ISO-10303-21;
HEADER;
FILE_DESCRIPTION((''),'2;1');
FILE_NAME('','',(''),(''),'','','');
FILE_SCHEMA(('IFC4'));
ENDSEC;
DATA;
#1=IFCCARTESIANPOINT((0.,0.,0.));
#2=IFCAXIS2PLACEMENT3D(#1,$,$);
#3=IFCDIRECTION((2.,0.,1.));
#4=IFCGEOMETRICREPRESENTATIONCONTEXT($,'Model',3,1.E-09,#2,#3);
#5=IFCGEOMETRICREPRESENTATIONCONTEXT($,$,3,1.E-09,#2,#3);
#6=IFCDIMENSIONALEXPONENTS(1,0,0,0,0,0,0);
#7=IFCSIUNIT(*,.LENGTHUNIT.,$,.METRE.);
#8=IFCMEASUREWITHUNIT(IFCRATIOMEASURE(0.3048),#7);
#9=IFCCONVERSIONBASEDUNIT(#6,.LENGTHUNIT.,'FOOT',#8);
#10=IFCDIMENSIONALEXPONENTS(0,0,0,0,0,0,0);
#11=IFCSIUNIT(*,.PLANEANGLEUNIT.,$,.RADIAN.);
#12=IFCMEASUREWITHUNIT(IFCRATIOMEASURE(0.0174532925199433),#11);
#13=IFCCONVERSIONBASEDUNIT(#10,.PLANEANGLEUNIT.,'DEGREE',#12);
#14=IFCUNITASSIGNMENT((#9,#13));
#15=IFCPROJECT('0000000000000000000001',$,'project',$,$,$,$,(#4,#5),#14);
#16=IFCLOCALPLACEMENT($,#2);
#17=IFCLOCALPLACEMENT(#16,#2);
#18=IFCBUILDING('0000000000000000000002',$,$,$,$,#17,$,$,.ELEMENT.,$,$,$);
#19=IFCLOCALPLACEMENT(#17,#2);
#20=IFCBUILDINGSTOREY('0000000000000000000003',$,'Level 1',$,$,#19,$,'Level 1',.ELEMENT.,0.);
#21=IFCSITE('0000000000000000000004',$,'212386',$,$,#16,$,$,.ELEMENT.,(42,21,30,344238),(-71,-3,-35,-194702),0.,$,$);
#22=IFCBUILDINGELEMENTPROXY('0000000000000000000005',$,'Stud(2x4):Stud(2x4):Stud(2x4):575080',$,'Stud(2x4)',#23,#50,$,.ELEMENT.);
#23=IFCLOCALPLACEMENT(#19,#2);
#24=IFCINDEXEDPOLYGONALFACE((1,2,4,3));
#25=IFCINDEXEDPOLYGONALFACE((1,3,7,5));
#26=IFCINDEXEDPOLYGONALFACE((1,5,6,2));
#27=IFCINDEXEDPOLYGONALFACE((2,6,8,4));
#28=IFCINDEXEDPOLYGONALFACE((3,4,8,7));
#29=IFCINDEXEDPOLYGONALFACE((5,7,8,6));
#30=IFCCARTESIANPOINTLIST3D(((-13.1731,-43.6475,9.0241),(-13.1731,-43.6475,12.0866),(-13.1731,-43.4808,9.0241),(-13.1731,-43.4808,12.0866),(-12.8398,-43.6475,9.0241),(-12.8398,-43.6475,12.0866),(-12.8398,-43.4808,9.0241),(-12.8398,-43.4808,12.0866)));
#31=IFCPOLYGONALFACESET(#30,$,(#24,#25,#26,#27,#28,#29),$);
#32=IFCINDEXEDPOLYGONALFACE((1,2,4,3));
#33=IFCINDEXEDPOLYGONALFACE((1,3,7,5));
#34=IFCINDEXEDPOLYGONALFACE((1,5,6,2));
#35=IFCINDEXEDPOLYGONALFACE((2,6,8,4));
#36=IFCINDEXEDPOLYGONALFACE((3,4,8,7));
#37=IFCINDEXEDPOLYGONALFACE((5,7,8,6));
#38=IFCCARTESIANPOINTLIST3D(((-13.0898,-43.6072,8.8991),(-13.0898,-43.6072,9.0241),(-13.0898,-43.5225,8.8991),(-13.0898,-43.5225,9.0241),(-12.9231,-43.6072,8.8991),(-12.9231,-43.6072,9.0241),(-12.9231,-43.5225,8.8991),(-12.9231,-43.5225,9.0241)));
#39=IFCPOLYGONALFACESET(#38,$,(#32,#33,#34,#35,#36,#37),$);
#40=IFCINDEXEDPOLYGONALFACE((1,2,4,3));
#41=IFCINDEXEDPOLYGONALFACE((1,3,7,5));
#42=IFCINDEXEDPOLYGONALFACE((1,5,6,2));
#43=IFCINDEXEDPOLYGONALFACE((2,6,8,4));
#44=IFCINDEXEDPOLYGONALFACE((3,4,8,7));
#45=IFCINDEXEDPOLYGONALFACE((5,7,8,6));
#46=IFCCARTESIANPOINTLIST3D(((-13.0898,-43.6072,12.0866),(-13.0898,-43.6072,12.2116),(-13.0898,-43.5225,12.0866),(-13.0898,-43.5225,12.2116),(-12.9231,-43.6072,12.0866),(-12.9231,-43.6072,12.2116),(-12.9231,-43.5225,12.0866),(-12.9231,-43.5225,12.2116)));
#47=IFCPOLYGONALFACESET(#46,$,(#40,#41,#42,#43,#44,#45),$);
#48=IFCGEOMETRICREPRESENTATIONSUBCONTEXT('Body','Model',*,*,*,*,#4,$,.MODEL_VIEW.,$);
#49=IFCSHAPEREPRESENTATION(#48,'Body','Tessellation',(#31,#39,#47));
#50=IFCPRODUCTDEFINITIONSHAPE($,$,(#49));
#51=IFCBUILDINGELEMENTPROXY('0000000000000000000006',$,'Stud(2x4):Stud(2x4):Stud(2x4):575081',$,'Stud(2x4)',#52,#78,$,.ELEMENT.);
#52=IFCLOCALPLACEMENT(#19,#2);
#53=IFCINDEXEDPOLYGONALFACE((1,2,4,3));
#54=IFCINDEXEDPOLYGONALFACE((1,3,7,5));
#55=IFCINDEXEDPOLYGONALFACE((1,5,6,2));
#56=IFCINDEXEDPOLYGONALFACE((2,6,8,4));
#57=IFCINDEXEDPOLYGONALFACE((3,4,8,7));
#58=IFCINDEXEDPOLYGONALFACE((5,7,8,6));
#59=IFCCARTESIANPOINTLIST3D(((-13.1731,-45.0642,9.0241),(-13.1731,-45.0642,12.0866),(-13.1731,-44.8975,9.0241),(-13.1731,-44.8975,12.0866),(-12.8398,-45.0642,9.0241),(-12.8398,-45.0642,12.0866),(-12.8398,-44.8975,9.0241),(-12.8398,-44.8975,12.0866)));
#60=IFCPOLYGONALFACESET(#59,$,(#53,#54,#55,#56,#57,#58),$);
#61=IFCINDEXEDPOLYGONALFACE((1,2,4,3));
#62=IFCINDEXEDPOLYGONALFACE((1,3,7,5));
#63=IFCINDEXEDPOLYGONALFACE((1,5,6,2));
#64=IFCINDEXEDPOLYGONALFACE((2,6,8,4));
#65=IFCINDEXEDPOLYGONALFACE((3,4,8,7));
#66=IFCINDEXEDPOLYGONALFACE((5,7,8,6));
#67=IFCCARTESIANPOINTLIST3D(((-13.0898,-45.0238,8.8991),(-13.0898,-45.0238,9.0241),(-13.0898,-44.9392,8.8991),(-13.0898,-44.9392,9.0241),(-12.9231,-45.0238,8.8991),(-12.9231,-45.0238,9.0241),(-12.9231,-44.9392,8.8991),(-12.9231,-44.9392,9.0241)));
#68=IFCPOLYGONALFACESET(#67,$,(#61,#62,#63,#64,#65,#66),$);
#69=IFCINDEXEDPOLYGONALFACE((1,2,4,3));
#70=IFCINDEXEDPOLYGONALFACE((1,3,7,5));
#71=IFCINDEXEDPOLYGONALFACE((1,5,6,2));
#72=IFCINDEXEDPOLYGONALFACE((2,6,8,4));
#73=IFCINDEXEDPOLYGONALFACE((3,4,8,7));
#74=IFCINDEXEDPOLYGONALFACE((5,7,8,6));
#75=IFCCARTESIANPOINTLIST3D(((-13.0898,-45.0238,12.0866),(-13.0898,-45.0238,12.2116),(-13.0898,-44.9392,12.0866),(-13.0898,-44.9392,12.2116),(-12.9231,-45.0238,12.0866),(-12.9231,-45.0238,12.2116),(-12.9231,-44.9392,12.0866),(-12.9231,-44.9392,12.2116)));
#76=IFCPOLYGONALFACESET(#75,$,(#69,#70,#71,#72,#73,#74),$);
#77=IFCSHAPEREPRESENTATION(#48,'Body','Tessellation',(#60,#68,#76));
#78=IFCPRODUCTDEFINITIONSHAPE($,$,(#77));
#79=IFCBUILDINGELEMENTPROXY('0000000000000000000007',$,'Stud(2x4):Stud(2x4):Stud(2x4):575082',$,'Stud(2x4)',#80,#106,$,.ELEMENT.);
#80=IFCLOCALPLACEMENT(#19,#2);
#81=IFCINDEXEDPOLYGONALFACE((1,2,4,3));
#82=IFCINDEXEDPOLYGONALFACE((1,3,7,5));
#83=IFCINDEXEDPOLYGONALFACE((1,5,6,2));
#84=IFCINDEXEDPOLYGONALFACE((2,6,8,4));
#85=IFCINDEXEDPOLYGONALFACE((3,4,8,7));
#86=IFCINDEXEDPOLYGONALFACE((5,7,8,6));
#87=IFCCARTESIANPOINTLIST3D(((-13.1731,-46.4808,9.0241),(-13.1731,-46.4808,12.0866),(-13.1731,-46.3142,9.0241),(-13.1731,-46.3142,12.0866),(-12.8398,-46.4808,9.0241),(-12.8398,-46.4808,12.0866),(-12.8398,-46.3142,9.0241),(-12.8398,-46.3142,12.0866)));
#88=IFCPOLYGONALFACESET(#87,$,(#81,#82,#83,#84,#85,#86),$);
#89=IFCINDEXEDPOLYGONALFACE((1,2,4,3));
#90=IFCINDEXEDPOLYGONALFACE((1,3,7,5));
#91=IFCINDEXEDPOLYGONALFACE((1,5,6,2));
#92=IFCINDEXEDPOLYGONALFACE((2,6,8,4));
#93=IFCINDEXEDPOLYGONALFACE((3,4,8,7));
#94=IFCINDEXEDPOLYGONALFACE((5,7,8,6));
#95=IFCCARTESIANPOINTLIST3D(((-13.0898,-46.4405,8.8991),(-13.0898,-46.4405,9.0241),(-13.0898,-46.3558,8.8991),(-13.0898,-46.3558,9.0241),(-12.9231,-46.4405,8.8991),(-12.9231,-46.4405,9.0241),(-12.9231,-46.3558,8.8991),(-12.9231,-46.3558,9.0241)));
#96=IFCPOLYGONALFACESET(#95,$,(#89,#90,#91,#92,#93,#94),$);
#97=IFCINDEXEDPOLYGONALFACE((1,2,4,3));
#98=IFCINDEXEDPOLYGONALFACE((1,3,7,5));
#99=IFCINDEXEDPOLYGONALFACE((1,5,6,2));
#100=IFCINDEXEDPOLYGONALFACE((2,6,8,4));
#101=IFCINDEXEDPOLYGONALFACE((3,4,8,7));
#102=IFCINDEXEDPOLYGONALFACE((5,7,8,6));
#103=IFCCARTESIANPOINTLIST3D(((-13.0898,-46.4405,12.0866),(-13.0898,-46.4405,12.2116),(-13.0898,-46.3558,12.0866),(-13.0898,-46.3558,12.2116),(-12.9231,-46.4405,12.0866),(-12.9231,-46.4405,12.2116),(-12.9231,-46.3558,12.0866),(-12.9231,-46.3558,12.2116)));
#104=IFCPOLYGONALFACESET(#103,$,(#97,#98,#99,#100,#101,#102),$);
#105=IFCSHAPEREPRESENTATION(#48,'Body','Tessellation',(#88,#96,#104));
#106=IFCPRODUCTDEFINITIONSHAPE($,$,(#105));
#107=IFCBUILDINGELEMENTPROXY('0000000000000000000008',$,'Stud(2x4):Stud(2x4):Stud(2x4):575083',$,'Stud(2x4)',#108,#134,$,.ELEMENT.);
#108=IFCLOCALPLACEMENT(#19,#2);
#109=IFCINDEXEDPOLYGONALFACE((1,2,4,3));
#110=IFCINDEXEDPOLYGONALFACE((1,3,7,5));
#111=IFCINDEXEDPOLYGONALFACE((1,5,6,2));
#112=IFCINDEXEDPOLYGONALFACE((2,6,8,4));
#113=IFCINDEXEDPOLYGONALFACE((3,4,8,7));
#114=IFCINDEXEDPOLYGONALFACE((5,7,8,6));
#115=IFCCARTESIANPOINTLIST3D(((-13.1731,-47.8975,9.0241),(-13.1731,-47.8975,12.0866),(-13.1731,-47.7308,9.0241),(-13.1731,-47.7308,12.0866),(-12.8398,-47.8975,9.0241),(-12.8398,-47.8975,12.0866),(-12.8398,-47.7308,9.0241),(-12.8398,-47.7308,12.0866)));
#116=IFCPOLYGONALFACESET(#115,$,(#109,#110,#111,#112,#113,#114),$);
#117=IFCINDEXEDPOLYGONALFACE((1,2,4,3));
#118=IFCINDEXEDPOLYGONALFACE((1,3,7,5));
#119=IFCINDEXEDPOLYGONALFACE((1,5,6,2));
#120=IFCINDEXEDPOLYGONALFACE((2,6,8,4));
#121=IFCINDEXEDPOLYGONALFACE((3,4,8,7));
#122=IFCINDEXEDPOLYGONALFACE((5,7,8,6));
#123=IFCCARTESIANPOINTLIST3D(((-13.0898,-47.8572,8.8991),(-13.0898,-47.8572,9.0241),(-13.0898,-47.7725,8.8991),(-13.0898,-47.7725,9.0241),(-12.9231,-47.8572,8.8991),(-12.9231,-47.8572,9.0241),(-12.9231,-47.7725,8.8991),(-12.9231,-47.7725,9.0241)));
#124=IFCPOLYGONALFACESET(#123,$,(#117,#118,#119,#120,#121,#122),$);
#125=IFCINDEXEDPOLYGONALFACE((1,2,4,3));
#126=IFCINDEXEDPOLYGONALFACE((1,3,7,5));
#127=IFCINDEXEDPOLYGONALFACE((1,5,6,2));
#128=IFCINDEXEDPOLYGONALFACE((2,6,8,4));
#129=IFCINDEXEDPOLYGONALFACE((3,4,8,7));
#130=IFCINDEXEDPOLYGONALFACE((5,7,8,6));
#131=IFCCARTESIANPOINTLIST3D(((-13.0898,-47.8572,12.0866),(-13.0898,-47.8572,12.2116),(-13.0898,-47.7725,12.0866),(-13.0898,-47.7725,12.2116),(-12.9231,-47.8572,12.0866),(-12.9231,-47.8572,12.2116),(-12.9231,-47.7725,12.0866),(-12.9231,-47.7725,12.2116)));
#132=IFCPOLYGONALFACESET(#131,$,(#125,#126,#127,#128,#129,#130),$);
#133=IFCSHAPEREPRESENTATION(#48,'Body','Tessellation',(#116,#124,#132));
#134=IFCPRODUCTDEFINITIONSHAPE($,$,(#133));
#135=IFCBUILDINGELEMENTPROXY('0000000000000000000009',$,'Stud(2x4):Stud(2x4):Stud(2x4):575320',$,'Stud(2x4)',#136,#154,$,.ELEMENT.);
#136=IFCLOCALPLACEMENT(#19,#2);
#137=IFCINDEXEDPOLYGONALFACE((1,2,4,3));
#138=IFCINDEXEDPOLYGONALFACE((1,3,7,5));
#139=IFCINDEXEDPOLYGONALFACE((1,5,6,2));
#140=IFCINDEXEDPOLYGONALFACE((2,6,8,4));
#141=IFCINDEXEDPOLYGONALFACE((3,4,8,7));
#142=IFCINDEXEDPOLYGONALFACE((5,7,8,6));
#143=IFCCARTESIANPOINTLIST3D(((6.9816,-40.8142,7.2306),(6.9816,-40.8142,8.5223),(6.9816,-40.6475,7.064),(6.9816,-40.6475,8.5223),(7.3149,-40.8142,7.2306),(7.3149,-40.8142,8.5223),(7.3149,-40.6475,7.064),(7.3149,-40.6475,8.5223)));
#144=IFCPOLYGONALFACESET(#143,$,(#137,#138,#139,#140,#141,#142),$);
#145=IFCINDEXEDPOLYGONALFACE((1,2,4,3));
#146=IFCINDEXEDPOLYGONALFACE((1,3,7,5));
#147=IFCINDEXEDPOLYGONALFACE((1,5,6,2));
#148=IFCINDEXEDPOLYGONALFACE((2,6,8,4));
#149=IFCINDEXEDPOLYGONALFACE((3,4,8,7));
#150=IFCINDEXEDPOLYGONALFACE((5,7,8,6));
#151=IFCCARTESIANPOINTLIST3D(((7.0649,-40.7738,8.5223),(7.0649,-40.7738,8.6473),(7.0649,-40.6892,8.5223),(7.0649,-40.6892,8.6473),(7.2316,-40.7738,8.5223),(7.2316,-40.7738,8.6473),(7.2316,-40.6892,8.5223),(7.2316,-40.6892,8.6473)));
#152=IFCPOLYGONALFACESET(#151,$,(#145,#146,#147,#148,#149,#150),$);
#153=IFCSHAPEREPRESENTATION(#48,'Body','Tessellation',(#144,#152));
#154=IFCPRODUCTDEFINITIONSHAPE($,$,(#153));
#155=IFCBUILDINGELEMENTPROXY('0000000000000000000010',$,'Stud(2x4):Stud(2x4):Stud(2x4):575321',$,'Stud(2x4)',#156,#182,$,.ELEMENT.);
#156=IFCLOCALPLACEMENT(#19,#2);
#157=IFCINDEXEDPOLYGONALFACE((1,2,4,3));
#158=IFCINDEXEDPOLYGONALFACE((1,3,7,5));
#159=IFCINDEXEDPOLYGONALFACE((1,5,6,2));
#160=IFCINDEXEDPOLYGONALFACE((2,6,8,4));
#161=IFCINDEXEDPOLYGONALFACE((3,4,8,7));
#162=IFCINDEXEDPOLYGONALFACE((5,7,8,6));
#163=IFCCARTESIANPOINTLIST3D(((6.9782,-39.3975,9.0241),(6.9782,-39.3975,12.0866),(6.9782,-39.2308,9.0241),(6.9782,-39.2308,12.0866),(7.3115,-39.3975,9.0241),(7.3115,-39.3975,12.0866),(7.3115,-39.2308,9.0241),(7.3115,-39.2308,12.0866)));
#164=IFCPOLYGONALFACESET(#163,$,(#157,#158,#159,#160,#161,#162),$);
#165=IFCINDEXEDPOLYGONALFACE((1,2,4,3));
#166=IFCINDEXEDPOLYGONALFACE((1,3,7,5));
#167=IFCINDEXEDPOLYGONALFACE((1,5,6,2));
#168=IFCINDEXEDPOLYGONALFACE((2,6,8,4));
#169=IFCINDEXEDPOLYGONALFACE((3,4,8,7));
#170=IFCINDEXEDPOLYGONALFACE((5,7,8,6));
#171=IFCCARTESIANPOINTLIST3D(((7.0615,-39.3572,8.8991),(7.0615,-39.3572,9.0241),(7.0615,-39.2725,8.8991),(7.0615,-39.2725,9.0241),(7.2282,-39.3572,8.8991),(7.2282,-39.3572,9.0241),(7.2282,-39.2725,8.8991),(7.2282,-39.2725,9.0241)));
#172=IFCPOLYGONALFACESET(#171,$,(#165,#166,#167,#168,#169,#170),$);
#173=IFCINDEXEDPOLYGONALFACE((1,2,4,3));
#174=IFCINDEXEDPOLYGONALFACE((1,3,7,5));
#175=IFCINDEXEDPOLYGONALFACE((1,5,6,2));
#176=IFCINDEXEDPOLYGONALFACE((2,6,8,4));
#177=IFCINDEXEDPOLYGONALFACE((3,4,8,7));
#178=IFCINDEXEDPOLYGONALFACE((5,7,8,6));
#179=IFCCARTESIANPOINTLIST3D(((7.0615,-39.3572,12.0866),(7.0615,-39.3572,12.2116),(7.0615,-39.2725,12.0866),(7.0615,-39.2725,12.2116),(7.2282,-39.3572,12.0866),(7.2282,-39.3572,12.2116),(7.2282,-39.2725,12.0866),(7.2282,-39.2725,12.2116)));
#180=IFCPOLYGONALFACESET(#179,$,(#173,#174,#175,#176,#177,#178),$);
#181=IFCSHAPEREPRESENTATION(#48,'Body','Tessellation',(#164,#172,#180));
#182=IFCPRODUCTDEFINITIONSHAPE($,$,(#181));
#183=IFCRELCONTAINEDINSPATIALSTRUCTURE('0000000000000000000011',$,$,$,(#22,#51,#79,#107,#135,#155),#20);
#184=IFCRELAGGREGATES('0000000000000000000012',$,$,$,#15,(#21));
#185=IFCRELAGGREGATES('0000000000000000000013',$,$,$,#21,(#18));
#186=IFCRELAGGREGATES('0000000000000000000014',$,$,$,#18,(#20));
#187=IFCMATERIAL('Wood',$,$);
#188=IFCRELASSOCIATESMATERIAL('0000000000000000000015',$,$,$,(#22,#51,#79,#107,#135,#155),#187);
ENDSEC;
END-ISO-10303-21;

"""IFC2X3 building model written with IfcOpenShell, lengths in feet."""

from ifc_helpers import new_model, entity, si_unit, converted_unit, direction, frame, frame_2d, origin, place, context, subcontext, project, spatial, polyline, rectangle, outline, extrude, source, transform, mapped, material, element, save


model = new_model("IFC2X3")

# Units and contexts
model_context = context("Model", 3, precision=1e-09, world=origin(), true_north=direction((2.0, 0.0, 1.0)))
context_of_model = context(None, 3, precision=1e-09, world=origin(), true_north=direction((2.0, 0.0, 1.0)))
body_context = subcontext(model_context, "Body", "Model", "MODEL_VIEW")
ifc_project = project(units=[converted_unit("LENGTHUNIT", "FOOT", entity("IfcRatioMeasure", 0.3048), si_unit("LENGTHUNIT", "METRE"), dimensions=[1, 0, 0, 0, 0, 0, 0]), converted_unit("PLANEANGLEUNIT", "DEGREE", entity("IfcRatioMeasure", 0.0174532925199433), si_unit("PLANEANGLEUNIT", "RADIAN"), dimensions=[0, 0, 0, 0, 0, 0, 0])], contexts=[model_context, context_of_model])

# Site, building, storey
site_placement = place(None, origin())
site = spatial("IfcSite", under=ifc_project, at=site_placement, Name="212386", CompositionType="ELEMENT", RefLatitude=(42, 21, 30, 344238), RefLongitude=(-71, -3, -35, -194702), RefElevation=0.0)
building_placement = place(site_placement, origin())
building = spatial("IfcBuilding", under=site, at=building_placement, CompositionType="ELEMENT")
storey_placement = place(building_placement, origin())
storey = spatial("IfcBuildingStorey", under=building, at=storey_placement, Name="Level 1", LongName="Level 1", CompositionType="ELEMENT", Elevation=0.0)

# Building element proxies
ifc_material = material(Name="Wood")
shared_shape_1 = source(origin(), body_context, "Body", "SweptSolid", [
    extrude(rectangle(XDim=0.3333, YDim=0.1667, at=frame_2d((0.0, 0.0), x_axis=(1.0, 0.0))), frame((-13.0064, -43.5642, 9.0241), z_axis=(0.0, 0.0, 1.0), x_axis=(-1.0, 0.0, 0.0)), (0.0, 0.0, 1.0), 3.0625),
    extrude(rectangle(XDim=0.1667, YDim=0.0847, at=frame_2d((0.0, 0.0), x_axis=(1.0, 0.0))), frame((-13.0064, -43.5648, 8.8991), z_axis=(0.0, 0.0, 1.0), x_axis=(-1.0, 0.0, 0.0)), (0.0, 0.0, 1.0), 0.125),
    extrude(rectangle(XDim=0.0847, YDim=0.1667, at=frame_2d((0.0, 0.0), x_axis=(1.0, 0.0))), frame((-13.0064, -43.5648, 12.0866), z_axis=(0.0, 0.0, 1.0), x_axis=(0.0, -1.0, 0.0)), (0.0, 0.0, 1.0), 0.125),
])
proxy_1_placement = place(storey_placement, origin())
element("IfcBuildingElementProxy", 1, at=proxy_1_placement, inside=storey, material=ifc_material, Name="Stud(2x4):Stud(2x4):Stud(2x4):575080", ObjectType="Stud(2x4)", CompositionType="ELEMENT", context=body_context, shape_type="MappedRepresentation", body=[
    mapped(shared_shape_1, transform((0.0, 0.0, 0.0), scale=1.0)),
])
shared_shape_2 = source(origin(), body_context, "Body", "SweptSolid", [
    extrude(rectangle(XDim=0.3333, YDim=0.1667, at=frame_2d((0.0, 0.0), x_axis=(1.0, 0.0))), frame((-13.0064, -44.9808, 9.0241), z_axis=(0.0, 0.0, 1.0), x_axis=(-1.0, 0.0, 0.0)), (0.0, 0.0, 1.0), 3.0625),
    extrude(rectangle(XDim=0.1667, YDim=0.0847, at=frame_2d((0.0, 0.0), x_axis=(1.0, 0.0))), frame((-13.0064, -44.9815, 8.8991), z_axis=(0.0, 0.0, 1.0), x_axis=(-1.0, 0.0, 0.0)), (0.0, 0.0, 1.0), 0.125),
    extrude(rectangle(XDim=0.0847, YDim=0.1667, at=frame_2d((0.0, 0.0), x_axis=(1.0, 0.0))), frame((-13.0064, -44.9815, 12.0866), z_axis=(0.0, 0.0, 1.0), x_axis=(0.0, -1.0, 0.0)), (0.0, 0.0, 1.0), 0.125),
])
proxy_2_placement = place(storey_placement, origin())
element("IfcBuildingElementProxy", 2, at=proxy_2_placement, inside=storey, material=ifc_material, Name="Stud(2x4):Stud(2x4):Stud(2x4):575081", ObjectType="Stud(2x4)", CompositionType="ELEMENT", context=body_context, shape_type="MappedRepresentation", body=[
    mapped(shared_shape_2, transform((0.0, 0.0, 0.0), scale=1.0)),
])
shared_shape_3 = source(origin(), body_context, "Body", "SweptSolid", [
    extrude(rectangle(XDim=0.3333, YDim=0.1667, at=frame_2d((0.0, 0.0), x_axis=(1.0, 0.0))), frame((-13.0064, -46.3975, 9.0241), z_axis=(0.0, 0.0, 1.0), x_axis=(-1.0, 0.0, 0.0)), (0.0, 0.0, 1.0), 3.0625),
    extrude(rectangle(XDim=0.1667, YDim=0.0847, at=frame_2d((0.0, 0.0), x_axis=(1.0, 0.0))), frame((-13.0064, -46.3982, 8.8991), z_axis=(0.0, 0.0, 1.0), x_axis=(-1.0, 0.0, 0.0)), (0.0, 0.0, 1.0), 0.125),
    extrude(rectangle(XDim=0.0847, YDim=0.1667, at=frame_2d((0.0, 0.0), x_axis=(1.0, 0.0))), frame((-13.0064, -46.3982, 12.0866), z_axis=(0.0, 0.0, 1.0), x_axis=(0.0, -1.0, 0.0)), (0.0, 0.0, 1.0), 0.125),
])
proxy_3_placement = place(storey_placement, origin())
element("IfcBuildingElementProxy", 3, at=proxy_3_placement, inside=storey, material=ifc_material, Name="Stud(2x4):Stud(2x4):Stud(2x4):575082", ObjectType="Stud(2x4)", CompositionType="ELEMENT", context=body_context, shape_type="MappedRepresentation", body=[
    mapped(shared_shape_3, transform((0.0, 0.0, 0.0), scale=1.0)),
])
shared_shape_4 = source(origin(), body_context, "Body", "SweptSolid", [
    extrude(rectangle(XDim=0.3333, YDim=0.1667, at=frame_2d((0.0, 0.0), x_axis=(1.0, 0.0))), frame((-13.0064, -47.8142, 9.0241), z_axis=(0.0, 0.0, 1.0), x_axis=(-1.0, 0.0, 0.0)), (0.0, 0.0, 1.0), 3.0625),
    extrude(rectangle(XDim=0.1667, YDim=0.0847, at=frame_2d((0.0, 0.0), x_axis=(1.0, 0.0))), frame((-13.0064, -47.8148, 8.8991), z_axis=(0.0, 0.0, 1.0), x_axis=(-1.0, 0.0, 0.0)), (0.0, 0.0, 1.0), 0.125),
    extrude(rectangle(XDim=0.0847, YDim=0.1667, at=frame_2d((0.0, 0.0), x_axis=(1.0, 0.0))), frame((-13.0064, -47.8148, 12.0866), z_axis=(0.0, 0.0, 1.0), x_axis=(0.0, -1.0, 0.0)), (0.0, 0.0, 1.0), 0.125),
])
proxy_4_placement = place(storey_placement, origin())
element("IfcBuildingElementProxy", 4, at=proxy_4_placement, inside=storey, material=ifc_material, Name="Stud(2x4):Stud(2x4):Stud(2x4):575083", ObjectType="Stud(2x4)", CompositionType="ELEMENT", context=body_context, shape_type="MappedRepresentation", body=[
    mapped(shared_shape_4, transform((0.0, 0.0, 0.0), scale=1.0)),
])
shared_shape_5 = source(origin(), body_context, "Body", "SweptSolid", [
    extrude(outline(polyline([(-0.6875, -0.0833), (0.6042, -0.0833), (0.7708, 0.0833), (-0.6875, 0.0833), (-0.6875, -0.0833)])), frame((6.9816, -40.7308, 7.8348), z_axis=(1.0, 0.0, 0.0), x_axis=(0.0, 0.0, -1.0)), (0.0, 0.0, 1.0), 0.3333),
    extrude(rectangle(XDim=0.1667, YDim=0.0847, at=frame_2d((0.0, 0.0), x_axis=(1.0, 0.0))), frame((7.1482, -40.7315, 8.5223), z_axis=(0.0, 0.0, 1.0), x_axis=(-1.0, 0.0, 0.0)), (0.0, 0.0, 1.0), 0.125),
])
proxy_5_placement = place(storey_placement, origin())
element("IfcBuildingElementProxy", 5, at=proxy_5_placement, inside=storey, material=ifc_material, Name="Stud(2x4):Stud(2x4):Stud(2x4):575320", ObjectType="Stud(2x4)", CompositionType="ELEMENT", context=body_context, shape_type="MappedRepresentation", body=[
    mapped(shared_shape_5, transform((0.0, 0.0, 0.0), scale=1.0)),
])
shared_shape_6 = source(origin(), body_context, "Body", "SweptSolid", [
    extrude(rectangle(XDim=0.3333, YDim=0.1667, at=frame_2d((0.0, 0.0), x_axis=(1.0, 0.0))), frame((7.1448, -39.3142, 9.0241), z_axis=(0.0, 0.0, 1.0), x_axis=(-1.0, 0.0, 0.0)), (0.0, 0.0, 1.0), 3.0625),
    extrude(rectangle(XDim=0.1667, YDim=0.0847, at=frame_2d((0.0, 0.0), x_axis=(1.0, 0.0))), frame((7.1448, -39.3148, 8.8991), z_axis=(0.0, 0.0, 1.0), x_axis=(-1.0, 0.0, 0.0)), (0.0, 0.0, 1.0), 0.125),
    extrude(rectangle(XDim=0.0847, YDim=0.1667, at=frame_2d((0.0, 0.0), x_axis=(1.0, 0.0))), frame((7.1448, -39.3148, 12.0866), z_axis=(0.0, 0.0, 1.0), x_axis=(0.0, -1.0, 0.0)), (0.0, 0.0, 1.0), 0.125),
])
proxy_6_placement = place(storey_placement, origin())
element("IfcBuildingElementProxy", 6, at=proxy_6_placement, inside=storey, material=ifc_material, Name="Stud(2x4):Stud(2x4):Stud(2x4):575321", ObjectType="Stud(2x4)", CompositionType="ELEMENT", context=body_context, shape_type="MappedRepresentation", body=[
    mapped(shared_shape_6, transform((0.0, 0.0, 0.0), scale=1.0)),
])

save(model, "model.ifc")
